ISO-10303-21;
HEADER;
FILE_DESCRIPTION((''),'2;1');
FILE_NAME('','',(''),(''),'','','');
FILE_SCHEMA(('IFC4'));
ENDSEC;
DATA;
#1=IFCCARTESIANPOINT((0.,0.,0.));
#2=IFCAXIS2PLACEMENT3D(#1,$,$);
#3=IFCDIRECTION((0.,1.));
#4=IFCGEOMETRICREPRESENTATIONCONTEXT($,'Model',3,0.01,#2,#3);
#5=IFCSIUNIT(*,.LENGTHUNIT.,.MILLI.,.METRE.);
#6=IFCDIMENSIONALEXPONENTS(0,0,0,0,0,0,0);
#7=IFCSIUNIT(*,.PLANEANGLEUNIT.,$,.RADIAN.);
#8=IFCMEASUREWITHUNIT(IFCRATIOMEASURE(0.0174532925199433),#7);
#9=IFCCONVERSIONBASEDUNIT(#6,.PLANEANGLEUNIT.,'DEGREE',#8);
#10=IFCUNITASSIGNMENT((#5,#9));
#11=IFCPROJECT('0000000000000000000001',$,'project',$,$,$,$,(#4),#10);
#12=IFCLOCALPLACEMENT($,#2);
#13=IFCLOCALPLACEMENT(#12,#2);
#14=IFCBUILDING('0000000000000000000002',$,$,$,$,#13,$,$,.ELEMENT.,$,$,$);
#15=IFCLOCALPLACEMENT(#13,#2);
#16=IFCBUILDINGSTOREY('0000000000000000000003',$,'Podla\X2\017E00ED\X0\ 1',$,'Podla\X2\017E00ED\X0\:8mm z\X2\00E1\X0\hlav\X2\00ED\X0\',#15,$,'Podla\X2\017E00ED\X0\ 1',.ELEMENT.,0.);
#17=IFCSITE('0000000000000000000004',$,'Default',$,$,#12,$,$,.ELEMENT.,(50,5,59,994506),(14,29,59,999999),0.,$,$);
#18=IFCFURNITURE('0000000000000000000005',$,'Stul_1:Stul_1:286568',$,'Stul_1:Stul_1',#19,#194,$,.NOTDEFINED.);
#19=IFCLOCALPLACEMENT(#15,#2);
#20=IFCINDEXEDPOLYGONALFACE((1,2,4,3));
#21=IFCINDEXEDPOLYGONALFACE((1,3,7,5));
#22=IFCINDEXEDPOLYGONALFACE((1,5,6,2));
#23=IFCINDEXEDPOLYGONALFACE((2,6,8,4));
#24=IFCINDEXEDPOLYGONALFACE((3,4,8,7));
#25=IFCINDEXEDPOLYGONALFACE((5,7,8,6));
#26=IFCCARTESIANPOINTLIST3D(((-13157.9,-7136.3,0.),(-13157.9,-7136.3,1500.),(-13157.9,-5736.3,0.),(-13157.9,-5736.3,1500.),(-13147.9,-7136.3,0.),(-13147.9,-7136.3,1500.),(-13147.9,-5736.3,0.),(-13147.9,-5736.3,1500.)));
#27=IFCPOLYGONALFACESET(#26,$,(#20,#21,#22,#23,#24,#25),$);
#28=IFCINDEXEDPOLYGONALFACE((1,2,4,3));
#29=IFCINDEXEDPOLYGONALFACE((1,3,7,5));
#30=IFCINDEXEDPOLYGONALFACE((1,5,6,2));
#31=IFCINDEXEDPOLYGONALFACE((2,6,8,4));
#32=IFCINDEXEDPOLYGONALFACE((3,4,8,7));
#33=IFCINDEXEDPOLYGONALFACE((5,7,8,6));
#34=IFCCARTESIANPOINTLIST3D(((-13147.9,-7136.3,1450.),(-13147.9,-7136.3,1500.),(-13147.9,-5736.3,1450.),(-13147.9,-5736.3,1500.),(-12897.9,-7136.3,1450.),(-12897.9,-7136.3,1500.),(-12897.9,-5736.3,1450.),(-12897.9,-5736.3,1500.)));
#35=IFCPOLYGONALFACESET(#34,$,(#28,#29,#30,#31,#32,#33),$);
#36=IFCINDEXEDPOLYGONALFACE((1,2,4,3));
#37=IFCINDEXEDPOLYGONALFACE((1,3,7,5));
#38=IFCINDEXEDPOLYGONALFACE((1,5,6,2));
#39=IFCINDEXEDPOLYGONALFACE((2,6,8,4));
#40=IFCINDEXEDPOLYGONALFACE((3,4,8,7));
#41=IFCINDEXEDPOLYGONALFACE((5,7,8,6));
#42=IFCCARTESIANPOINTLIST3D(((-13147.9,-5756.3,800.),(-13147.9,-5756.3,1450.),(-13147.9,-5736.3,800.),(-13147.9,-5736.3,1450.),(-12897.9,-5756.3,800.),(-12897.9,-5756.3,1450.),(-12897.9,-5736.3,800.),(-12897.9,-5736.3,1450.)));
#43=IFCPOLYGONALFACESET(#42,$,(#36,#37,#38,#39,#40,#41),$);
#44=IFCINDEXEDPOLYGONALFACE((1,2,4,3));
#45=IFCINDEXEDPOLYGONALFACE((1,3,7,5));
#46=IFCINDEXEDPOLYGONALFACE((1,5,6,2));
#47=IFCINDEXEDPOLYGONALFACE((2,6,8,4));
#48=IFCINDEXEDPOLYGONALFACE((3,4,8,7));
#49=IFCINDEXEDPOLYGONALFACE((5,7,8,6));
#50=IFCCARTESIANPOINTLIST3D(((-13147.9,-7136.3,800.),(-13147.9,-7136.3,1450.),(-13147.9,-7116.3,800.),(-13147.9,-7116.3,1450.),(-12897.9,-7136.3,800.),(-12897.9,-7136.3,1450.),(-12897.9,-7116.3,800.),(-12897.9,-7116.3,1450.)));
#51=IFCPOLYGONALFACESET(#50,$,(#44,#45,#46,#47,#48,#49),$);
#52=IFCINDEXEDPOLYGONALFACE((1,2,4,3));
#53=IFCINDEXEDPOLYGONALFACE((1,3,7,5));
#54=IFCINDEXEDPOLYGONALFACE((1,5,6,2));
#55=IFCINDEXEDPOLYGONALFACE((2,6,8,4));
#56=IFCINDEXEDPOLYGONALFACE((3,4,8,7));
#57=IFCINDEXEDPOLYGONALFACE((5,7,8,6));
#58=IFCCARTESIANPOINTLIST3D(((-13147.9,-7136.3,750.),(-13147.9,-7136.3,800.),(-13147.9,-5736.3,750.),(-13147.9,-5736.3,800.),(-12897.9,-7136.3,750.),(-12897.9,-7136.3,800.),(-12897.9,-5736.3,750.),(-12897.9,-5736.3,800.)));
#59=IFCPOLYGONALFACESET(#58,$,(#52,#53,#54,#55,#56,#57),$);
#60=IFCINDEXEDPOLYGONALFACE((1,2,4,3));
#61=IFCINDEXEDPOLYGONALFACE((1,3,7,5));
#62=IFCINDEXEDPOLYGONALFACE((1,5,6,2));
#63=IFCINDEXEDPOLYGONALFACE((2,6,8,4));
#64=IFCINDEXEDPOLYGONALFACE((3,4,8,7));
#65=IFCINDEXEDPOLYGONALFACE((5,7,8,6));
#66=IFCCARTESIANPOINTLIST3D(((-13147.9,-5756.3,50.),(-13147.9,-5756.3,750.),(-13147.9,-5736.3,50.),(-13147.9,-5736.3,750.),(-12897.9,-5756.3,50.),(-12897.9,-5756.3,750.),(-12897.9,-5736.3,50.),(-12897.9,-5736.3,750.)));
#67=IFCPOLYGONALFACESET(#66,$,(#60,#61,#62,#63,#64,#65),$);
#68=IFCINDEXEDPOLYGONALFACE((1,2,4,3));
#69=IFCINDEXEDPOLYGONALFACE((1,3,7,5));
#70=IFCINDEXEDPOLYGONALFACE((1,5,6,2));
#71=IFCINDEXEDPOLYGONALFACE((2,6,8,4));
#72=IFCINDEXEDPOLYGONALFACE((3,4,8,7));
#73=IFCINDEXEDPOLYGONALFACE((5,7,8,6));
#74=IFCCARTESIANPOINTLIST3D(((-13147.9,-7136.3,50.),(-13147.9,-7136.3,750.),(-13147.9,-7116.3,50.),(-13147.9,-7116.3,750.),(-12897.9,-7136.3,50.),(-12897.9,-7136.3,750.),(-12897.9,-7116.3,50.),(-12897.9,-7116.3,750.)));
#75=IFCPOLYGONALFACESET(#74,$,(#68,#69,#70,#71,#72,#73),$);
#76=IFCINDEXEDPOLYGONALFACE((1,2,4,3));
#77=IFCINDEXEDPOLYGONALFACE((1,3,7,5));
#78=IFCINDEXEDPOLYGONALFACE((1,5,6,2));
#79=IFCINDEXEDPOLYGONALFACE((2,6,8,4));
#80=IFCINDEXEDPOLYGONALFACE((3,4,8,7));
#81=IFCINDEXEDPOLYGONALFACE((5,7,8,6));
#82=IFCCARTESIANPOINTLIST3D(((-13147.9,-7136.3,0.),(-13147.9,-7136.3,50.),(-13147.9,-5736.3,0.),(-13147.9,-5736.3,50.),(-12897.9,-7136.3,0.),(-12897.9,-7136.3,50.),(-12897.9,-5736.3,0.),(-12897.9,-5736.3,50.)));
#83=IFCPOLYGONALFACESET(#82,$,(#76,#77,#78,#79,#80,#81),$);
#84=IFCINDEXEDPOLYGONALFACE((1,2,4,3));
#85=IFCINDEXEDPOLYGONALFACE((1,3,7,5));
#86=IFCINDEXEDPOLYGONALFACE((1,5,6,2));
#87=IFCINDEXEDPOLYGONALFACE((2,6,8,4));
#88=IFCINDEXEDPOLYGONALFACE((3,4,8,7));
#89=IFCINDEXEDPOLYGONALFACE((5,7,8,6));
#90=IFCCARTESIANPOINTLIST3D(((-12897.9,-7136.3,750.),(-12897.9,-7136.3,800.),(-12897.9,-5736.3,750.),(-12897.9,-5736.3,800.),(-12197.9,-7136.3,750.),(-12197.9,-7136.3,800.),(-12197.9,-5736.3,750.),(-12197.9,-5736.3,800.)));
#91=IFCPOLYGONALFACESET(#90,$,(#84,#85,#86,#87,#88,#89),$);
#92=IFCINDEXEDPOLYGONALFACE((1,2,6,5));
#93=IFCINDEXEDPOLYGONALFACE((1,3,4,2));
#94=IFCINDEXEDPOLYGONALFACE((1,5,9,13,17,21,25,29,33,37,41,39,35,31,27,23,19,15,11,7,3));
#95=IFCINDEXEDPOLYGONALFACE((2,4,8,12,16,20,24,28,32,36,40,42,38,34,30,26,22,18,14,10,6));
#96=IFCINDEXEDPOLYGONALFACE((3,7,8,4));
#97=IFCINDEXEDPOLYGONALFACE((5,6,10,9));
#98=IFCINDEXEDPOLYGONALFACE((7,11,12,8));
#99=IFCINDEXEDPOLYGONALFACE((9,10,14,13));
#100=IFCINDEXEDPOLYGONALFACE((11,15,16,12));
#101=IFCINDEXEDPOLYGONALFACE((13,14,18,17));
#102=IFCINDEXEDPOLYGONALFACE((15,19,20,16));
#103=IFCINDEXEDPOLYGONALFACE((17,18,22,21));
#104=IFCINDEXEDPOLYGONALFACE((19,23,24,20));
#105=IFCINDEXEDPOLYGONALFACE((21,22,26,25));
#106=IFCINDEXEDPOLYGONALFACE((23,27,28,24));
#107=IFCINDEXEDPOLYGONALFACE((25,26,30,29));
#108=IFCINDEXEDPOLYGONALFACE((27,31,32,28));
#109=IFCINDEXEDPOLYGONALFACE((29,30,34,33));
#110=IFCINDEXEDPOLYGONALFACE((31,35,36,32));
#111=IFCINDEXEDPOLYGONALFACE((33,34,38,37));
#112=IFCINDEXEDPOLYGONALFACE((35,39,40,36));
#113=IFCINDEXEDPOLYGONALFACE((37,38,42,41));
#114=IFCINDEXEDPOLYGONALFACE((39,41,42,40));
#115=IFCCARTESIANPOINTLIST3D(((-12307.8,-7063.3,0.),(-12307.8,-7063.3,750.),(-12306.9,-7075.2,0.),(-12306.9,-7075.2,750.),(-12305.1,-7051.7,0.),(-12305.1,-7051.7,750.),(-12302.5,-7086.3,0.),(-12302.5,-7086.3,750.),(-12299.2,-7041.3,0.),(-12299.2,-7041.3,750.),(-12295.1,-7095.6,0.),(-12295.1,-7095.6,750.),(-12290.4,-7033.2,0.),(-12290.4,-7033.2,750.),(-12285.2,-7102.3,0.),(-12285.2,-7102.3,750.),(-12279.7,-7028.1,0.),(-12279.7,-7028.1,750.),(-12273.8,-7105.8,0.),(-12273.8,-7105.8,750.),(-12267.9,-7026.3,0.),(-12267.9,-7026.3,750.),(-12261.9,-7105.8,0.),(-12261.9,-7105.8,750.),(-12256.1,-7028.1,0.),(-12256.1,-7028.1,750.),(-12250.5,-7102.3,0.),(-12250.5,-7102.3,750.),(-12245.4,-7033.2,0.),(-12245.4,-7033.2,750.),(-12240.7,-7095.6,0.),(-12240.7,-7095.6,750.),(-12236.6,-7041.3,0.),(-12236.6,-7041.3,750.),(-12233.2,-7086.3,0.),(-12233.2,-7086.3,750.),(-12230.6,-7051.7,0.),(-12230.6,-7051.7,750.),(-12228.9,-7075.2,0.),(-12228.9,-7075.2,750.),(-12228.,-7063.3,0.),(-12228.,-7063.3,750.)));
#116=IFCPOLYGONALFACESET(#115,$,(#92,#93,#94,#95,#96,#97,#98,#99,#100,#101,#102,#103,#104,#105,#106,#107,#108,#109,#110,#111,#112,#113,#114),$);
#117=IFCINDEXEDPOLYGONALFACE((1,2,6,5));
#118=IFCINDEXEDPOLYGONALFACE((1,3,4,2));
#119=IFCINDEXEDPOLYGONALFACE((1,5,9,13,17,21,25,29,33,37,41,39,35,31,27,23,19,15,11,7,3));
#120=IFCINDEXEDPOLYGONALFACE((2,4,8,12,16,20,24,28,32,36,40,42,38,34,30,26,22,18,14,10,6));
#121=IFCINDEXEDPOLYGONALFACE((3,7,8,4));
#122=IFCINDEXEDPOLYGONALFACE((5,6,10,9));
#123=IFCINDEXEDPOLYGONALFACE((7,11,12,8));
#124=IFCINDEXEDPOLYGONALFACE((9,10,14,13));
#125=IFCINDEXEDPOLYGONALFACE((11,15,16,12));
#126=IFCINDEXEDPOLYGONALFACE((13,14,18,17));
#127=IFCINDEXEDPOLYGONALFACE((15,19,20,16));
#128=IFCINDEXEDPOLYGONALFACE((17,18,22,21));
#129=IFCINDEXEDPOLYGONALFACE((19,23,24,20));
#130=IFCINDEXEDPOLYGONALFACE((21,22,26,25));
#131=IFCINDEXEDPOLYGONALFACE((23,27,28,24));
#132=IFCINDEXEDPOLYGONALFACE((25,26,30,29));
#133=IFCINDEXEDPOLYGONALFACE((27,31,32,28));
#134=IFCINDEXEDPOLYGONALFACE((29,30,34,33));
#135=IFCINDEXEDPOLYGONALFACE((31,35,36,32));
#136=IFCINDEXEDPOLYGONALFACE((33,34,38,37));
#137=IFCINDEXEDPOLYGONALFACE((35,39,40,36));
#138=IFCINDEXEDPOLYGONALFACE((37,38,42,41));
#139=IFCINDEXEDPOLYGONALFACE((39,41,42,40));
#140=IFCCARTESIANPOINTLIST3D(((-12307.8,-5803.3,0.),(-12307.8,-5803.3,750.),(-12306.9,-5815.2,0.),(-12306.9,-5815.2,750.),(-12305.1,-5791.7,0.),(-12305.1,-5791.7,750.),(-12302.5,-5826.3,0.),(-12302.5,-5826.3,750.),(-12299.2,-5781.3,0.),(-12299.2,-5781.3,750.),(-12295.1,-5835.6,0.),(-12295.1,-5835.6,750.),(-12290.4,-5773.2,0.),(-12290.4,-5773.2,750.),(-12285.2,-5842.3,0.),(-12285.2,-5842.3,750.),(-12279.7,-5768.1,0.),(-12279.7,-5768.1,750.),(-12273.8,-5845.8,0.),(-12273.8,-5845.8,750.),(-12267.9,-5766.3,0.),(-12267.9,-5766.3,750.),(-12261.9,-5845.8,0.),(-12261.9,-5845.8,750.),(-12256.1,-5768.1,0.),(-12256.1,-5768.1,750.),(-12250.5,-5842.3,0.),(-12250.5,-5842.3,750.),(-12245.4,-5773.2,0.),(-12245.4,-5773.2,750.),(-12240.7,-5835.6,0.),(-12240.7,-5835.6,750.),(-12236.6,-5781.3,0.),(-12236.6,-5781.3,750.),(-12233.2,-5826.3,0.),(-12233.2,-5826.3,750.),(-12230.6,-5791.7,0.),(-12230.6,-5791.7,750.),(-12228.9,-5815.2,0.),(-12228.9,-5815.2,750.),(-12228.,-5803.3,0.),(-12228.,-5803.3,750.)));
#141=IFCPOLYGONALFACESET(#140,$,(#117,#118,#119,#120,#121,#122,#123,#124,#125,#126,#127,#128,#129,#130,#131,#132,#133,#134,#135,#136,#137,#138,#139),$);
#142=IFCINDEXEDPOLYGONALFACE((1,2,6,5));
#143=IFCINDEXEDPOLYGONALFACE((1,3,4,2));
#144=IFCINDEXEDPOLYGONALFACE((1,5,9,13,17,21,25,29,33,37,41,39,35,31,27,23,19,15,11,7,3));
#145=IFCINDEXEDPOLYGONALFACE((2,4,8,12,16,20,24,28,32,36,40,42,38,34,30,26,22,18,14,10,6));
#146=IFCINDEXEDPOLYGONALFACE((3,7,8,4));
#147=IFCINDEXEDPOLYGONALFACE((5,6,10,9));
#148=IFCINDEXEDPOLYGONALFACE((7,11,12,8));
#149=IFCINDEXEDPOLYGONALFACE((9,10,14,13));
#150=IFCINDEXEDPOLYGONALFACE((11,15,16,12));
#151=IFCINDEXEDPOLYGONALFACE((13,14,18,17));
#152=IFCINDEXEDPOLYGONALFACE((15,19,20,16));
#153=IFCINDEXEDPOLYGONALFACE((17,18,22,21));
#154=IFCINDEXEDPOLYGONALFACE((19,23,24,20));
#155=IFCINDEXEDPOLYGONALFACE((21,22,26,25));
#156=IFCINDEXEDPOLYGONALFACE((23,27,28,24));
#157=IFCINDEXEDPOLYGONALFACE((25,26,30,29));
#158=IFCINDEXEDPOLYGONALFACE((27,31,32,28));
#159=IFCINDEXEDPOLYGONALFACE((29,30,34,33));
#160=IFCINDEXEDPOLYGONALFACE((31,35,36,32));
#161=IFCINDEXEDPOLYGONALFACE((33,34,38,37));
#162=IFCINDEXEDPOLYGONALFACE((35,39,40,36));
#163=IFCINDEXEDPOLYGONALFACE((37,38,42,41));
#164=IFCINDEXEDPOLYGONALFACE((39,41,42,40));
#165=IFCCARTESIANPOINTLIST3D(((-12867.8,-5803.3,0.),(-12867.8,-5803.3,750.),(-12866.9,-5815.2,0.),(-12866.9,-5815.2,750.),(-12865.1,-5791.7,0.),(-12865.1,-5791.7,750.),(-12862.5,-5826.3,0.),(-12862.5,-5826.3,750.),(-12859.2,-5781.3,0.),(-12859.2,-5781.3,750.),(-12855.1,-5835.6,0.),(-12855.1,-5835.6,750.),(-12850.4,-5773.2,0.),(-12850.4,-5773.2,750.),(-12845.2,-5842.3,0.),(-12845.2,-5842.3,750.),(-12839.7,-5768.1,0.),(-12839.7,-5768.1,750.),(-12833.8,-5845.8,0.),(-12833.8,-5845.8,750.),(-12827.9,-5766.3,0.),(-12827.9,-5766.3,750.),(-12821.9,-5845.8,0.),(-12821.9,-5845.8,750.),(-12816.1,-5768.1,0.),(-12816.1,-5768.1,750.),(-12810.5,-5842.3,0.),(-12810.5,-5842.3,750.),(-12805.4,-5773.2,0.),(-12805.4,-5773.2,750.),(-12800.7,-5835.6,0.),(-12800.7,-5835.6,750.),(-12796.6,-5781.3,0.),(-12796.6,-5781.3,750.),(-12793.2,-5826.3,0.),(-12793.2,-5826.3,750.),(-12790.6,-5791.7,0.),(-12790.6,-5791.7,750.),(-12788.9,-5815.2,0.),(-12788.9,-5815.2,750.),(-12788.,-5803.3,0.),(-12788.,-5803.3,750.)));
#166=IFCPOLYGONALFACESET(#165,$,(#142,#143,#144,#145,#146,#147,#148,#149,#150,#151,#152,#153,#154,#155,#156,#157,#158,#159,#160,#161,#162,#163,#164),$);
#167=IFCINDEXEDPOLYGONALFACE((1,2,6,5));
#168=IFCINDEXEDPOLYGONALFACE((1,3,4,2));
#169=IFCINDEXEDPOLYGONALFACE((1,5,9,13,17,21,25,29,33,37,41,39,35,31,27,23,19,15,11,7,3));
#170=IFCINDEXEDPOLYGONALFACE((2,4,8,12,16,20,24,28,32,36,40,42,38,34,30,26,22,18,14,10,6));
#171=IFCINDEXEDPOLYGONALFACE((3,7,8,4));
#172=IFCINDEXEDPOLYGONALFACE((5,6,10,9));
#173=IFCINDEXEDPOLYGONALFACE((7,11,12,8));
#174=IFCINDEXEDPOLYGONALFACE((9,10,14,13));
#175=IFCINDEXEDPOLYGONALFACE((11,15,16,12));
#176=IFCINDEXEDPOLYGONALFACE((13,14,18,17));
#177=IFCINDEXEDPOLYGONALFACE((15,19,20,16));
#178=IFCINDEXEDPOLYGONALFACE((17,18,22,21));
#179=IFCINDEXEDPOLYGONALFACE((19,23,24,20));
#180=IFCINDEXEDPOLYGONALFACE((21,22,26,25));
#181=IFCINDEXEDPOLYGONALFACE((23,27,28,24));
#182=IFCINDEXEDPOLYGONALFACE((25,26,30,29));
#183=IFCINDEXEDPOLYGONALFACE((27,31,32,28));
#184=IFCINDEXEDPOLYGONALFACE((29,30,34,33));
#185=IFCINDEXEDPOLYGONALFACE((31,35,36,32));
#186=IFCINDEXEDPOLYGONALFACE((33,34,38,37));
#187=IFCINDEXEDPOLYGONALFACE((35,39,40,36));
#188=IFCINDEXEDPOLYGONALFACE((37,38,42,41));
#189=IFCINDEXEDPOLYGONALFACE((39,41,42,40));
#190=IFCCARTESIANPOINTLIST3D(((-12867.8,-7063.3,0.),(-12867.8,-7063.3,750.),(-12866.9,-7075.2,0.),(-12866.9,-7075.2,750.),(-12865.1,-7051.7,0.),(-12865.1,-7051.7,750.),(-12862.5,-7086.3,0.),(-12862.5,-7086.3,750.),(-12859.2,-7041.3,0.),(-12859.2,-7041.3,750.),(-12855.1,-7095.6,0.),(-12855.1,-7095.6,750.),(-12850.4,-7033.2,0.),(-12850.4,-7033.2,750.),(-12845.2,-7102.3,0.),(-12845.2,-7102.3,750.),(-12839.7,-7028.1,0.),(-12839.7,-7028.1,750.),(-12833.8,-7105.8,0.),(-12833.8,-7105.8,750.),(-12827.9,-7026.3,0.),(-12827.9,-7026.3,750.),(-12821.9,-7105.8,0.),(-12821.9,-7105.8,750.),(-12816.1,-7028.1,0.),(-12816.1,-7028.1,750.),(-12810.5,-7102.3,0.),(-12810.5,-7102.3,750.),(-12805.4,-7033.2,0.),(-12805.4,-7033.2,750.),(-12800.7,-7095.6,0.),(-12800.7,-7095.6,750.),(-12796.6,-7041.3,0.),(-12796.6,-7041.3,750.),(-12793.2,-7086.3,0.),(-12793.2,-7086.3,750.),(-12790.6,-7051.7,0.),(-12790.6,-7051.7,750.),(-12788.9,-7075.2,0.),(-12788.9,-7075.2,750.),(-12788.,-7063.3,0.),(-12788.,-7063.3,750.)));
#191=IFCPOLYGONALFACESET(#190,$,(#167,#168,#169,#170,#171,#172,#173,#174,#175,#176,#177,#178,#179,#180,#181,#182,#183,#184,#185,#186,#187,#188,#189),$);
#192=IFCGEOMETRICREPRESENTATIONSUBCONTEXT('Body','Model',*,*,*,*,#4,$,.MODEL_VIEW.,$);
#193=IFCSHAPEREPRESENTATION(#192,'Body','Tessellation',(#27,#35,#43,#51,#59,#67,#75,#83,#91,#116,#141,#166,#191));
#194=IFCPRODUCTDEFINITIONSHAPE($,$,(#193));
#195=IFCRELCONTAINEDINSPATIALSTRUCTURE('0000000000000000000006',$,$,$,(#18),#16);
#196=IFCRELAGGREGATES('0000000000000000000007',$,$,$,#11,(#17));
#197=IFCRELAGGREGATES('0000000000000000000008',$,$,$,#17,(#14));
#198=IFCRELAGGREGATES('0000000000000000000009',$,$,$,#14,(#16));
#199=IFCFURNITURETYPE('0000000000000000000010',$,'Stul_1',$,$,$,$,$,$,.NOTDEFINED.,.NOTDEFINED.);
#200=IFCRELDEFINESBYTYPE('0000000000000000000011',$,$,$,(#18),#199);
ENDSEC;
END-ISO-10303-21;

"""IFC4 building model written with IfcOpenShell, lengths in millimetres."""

from ifc_helpers import new_model, entity, si_unit, converted_unit, direction, frame, frame_2d, origin, origin_2d_with_axis, place, context, subcontext, project, spatial, rectangle, circle, extrude, source, transform, mapped, type_object, type_shapes, element, save


model = new_model("IFC4")

# Units and contexts
model_context = context("Model", 3, precision=0.01, world=origin(), true_north=direction((0.0, 1.0)))
body_context = subcontext(model_context, "Body", "Model", "MODEL_VIEW")
ifc_project = project(units=[si_unit("LENGTHUNIT", "METRE", prefix="MILLI"), converted_unit("PLANEANGLEUNIT", "DEGREE", entity("IfcRatioMeasure", 0.0174532925199433), si_unit("PLANEANGLEUNIT", "RADIAN"), dimensions=[0, 0, 0, 0, 0, 0, 0])], contexts=[model_context])

# Site, building, storey
site_placement = place(None, origin())
site = spatial("IfcSite", under=ifc_project, at=site_placement, Name="Default", CompositionType="ELEMENT", RefLatitude=(50, 5, 59, 994506), RefLongitude=(14, 29, 59, 999999), RefElevation=0.0)
building_placement = place(site_placement, origin())
building = spatial("IfcBuilding", under=site, at=building_placement, CompositionType="ELEMENT")
storey_placement = place(building_placement, origin())
storey = spatial("IfcBuildingStorey", under=building, at=storey_placement, Name="Podlaží 1", ObjectType="Podlaží:8mm záhlaví", LongName="Podlaží 1", CompositionType="ELEMENT", Elevation=0.0)

# Furniture
furniture_type = type_object("IfcFurnitureType", Name="Stul_1", AssemblyPlace="NOTDEFINED", PredefinedType="NOTDEFINED")
shared_shape_1 = source(origin(), body_context, "Body", "SweptSolid", [
    extrude(rectangle(XDim=1400.0, YDim=10.0, at=origin_2d_with_axis()), frame((0.0, 605.0, 0.0), z_axis=(0.0, 0.0, 1.0), x_axis=(-1.0, 0.0, 0.0)), (0.0, 0.0, 1.0), 1500.0),
    extrude(rectangle(XDim=1400.0, YDim=250.0, at=frame_2d((0.0, 0.0), x_axis=(1.0, 0.0))), frame((0.0, 475.0, 1450.0), z_axis=(0.0, 0.0, 1.0), x_axis=(-1.0, 0.0, 0.0)), (0.0, 0.0, 1.0), 50.0),
    extrude(rectangle(XDim=20.0, YDim=250.0, at=origin_2d_with_axis()), frame((690.0, 475.0, 800.0), z_axis=(0.0, 0.0, 1.0), x_axis=(-1.0, 0.0, 0.0)), (0.0, 0.0, 1.0), 650.0),
    extrude(rectangle(XDim=20.0, YDim=250.0, at=frame_2d((0.0, 0.0), x_axis=(1.0, 0.0))), frame((-690.0, 475.0, 800.0), z_axis=(0.0, 0.0, 1.0), x_axis=(-1.0, 0.0, 0.0)), (0.0, 0.0, 1.0), 650.0),
    extrude(rectangle(XDim=1400.0, YDim=250.0, at=origin_2d_with_axis()), frame((0.0, 475.0, 750.0), z_axis=(0.0, 0.0, 1.0), x_axis=(-1.0, 0.0, 0.0)), (0.0, 0.0, 1.0), 50.0),
    extrude(rectangle(XDim=20.0, YDim=250.0, at=origin_2d_with_axis()), frame((690.0, 475.0, 50.0), z_axis=(0.0, 0.0, 1.0), x_axis=(-1.0, 0.0, 0.0)), (0.0, 0.0, 1.0), 700.0),
    extrude(rectangle(XDim=20.0, YDim=250.0, at=frame_2d((0.0, 0.0), x_axis=(1.0, 0.0))), frame((-690.0, 475.0, 50.0), z_axis=(0.0, 0.0, 1.0), x_axis=(-1.0, 0.0, 0.0)), (0.0, 0.0, 1.0), 700.0),
    extrude(rectangle(XDim=1400.0, YDim=250.0, at=origin_2d_with_axis()), frame((0.0, 475.0, 0.0), z_axis=(0.0, 0.0, 1.0), x_axis=(-1.0, 0.0, 0.0)), (0.0, 0.0, 1.0), 50.0),
    extrude(rectangle(XDim=1400.0, YDim=700.0, at=origin_2d_with_axis()), frame((0.0, 0.0, 750.0), z_axis=(0.0, 0.0, 1.0), x_axis=(-1.0, 0.0, 0.0)), (0.0, 0.0, 1.0), 50.0),
    extrude(circle(Radius=40.0, at=frame_2d((0.0, 0.0), x_axis=(1.0, 0.0))), frame((-630.0, -280.0, 0.0)), (0.0, 0.0, 1.0), 750.0),
    extrude(circle(Radius=40.0, at=frame_2d((0.0, 0.0), x_axis=(1.0, 0.0))), frame((630.0, -280.0, 0.0)), (0.0, 0.0, 1.0), 750.0),
    extrude(circle(Radius=40.0, at=frame_2d((0.0, 0.0), x_axis=(1.0, 0.0))), frame((630.0, 280.0, 0.0)), (0.0, 0.0, 1.0), 750.0),
    extrude(circle(Radius=40.0, at=frame_2d((0.0, 0.0), x_axis=(1.0, 0.0))), frame((-630.0, 280.0, 0.0)), (0.0, 0.0, 1.0), 750.0),
])
type_shapes(furniture_type, [shared_shape_1])
for number, where, z_axis, x_axis, name in (
    (1, (-12547.9, -6436.3, 0.0), (0.0, 0.0, 1.0), (0.0, 1.0, 0.0), "Stul_1:Stul_1:286568"),
):
    element("IfcFurniture", number, at=place(storey_placement, frame(where, z_axis=z_axis, x_axis=x_axis)), inside=storey, type_object=furniture_type, Name=name, ObjectType="Stul_1:Stul_1", PredefinedType="NOTDEFINED", context=body_context, shape_type="MappedRepresentation", body=[
        mapped(shared_shape_1, transform((0.0, 0.0, 0.0), scale=1.0)),
    ])

save(model, "model.ifc")
